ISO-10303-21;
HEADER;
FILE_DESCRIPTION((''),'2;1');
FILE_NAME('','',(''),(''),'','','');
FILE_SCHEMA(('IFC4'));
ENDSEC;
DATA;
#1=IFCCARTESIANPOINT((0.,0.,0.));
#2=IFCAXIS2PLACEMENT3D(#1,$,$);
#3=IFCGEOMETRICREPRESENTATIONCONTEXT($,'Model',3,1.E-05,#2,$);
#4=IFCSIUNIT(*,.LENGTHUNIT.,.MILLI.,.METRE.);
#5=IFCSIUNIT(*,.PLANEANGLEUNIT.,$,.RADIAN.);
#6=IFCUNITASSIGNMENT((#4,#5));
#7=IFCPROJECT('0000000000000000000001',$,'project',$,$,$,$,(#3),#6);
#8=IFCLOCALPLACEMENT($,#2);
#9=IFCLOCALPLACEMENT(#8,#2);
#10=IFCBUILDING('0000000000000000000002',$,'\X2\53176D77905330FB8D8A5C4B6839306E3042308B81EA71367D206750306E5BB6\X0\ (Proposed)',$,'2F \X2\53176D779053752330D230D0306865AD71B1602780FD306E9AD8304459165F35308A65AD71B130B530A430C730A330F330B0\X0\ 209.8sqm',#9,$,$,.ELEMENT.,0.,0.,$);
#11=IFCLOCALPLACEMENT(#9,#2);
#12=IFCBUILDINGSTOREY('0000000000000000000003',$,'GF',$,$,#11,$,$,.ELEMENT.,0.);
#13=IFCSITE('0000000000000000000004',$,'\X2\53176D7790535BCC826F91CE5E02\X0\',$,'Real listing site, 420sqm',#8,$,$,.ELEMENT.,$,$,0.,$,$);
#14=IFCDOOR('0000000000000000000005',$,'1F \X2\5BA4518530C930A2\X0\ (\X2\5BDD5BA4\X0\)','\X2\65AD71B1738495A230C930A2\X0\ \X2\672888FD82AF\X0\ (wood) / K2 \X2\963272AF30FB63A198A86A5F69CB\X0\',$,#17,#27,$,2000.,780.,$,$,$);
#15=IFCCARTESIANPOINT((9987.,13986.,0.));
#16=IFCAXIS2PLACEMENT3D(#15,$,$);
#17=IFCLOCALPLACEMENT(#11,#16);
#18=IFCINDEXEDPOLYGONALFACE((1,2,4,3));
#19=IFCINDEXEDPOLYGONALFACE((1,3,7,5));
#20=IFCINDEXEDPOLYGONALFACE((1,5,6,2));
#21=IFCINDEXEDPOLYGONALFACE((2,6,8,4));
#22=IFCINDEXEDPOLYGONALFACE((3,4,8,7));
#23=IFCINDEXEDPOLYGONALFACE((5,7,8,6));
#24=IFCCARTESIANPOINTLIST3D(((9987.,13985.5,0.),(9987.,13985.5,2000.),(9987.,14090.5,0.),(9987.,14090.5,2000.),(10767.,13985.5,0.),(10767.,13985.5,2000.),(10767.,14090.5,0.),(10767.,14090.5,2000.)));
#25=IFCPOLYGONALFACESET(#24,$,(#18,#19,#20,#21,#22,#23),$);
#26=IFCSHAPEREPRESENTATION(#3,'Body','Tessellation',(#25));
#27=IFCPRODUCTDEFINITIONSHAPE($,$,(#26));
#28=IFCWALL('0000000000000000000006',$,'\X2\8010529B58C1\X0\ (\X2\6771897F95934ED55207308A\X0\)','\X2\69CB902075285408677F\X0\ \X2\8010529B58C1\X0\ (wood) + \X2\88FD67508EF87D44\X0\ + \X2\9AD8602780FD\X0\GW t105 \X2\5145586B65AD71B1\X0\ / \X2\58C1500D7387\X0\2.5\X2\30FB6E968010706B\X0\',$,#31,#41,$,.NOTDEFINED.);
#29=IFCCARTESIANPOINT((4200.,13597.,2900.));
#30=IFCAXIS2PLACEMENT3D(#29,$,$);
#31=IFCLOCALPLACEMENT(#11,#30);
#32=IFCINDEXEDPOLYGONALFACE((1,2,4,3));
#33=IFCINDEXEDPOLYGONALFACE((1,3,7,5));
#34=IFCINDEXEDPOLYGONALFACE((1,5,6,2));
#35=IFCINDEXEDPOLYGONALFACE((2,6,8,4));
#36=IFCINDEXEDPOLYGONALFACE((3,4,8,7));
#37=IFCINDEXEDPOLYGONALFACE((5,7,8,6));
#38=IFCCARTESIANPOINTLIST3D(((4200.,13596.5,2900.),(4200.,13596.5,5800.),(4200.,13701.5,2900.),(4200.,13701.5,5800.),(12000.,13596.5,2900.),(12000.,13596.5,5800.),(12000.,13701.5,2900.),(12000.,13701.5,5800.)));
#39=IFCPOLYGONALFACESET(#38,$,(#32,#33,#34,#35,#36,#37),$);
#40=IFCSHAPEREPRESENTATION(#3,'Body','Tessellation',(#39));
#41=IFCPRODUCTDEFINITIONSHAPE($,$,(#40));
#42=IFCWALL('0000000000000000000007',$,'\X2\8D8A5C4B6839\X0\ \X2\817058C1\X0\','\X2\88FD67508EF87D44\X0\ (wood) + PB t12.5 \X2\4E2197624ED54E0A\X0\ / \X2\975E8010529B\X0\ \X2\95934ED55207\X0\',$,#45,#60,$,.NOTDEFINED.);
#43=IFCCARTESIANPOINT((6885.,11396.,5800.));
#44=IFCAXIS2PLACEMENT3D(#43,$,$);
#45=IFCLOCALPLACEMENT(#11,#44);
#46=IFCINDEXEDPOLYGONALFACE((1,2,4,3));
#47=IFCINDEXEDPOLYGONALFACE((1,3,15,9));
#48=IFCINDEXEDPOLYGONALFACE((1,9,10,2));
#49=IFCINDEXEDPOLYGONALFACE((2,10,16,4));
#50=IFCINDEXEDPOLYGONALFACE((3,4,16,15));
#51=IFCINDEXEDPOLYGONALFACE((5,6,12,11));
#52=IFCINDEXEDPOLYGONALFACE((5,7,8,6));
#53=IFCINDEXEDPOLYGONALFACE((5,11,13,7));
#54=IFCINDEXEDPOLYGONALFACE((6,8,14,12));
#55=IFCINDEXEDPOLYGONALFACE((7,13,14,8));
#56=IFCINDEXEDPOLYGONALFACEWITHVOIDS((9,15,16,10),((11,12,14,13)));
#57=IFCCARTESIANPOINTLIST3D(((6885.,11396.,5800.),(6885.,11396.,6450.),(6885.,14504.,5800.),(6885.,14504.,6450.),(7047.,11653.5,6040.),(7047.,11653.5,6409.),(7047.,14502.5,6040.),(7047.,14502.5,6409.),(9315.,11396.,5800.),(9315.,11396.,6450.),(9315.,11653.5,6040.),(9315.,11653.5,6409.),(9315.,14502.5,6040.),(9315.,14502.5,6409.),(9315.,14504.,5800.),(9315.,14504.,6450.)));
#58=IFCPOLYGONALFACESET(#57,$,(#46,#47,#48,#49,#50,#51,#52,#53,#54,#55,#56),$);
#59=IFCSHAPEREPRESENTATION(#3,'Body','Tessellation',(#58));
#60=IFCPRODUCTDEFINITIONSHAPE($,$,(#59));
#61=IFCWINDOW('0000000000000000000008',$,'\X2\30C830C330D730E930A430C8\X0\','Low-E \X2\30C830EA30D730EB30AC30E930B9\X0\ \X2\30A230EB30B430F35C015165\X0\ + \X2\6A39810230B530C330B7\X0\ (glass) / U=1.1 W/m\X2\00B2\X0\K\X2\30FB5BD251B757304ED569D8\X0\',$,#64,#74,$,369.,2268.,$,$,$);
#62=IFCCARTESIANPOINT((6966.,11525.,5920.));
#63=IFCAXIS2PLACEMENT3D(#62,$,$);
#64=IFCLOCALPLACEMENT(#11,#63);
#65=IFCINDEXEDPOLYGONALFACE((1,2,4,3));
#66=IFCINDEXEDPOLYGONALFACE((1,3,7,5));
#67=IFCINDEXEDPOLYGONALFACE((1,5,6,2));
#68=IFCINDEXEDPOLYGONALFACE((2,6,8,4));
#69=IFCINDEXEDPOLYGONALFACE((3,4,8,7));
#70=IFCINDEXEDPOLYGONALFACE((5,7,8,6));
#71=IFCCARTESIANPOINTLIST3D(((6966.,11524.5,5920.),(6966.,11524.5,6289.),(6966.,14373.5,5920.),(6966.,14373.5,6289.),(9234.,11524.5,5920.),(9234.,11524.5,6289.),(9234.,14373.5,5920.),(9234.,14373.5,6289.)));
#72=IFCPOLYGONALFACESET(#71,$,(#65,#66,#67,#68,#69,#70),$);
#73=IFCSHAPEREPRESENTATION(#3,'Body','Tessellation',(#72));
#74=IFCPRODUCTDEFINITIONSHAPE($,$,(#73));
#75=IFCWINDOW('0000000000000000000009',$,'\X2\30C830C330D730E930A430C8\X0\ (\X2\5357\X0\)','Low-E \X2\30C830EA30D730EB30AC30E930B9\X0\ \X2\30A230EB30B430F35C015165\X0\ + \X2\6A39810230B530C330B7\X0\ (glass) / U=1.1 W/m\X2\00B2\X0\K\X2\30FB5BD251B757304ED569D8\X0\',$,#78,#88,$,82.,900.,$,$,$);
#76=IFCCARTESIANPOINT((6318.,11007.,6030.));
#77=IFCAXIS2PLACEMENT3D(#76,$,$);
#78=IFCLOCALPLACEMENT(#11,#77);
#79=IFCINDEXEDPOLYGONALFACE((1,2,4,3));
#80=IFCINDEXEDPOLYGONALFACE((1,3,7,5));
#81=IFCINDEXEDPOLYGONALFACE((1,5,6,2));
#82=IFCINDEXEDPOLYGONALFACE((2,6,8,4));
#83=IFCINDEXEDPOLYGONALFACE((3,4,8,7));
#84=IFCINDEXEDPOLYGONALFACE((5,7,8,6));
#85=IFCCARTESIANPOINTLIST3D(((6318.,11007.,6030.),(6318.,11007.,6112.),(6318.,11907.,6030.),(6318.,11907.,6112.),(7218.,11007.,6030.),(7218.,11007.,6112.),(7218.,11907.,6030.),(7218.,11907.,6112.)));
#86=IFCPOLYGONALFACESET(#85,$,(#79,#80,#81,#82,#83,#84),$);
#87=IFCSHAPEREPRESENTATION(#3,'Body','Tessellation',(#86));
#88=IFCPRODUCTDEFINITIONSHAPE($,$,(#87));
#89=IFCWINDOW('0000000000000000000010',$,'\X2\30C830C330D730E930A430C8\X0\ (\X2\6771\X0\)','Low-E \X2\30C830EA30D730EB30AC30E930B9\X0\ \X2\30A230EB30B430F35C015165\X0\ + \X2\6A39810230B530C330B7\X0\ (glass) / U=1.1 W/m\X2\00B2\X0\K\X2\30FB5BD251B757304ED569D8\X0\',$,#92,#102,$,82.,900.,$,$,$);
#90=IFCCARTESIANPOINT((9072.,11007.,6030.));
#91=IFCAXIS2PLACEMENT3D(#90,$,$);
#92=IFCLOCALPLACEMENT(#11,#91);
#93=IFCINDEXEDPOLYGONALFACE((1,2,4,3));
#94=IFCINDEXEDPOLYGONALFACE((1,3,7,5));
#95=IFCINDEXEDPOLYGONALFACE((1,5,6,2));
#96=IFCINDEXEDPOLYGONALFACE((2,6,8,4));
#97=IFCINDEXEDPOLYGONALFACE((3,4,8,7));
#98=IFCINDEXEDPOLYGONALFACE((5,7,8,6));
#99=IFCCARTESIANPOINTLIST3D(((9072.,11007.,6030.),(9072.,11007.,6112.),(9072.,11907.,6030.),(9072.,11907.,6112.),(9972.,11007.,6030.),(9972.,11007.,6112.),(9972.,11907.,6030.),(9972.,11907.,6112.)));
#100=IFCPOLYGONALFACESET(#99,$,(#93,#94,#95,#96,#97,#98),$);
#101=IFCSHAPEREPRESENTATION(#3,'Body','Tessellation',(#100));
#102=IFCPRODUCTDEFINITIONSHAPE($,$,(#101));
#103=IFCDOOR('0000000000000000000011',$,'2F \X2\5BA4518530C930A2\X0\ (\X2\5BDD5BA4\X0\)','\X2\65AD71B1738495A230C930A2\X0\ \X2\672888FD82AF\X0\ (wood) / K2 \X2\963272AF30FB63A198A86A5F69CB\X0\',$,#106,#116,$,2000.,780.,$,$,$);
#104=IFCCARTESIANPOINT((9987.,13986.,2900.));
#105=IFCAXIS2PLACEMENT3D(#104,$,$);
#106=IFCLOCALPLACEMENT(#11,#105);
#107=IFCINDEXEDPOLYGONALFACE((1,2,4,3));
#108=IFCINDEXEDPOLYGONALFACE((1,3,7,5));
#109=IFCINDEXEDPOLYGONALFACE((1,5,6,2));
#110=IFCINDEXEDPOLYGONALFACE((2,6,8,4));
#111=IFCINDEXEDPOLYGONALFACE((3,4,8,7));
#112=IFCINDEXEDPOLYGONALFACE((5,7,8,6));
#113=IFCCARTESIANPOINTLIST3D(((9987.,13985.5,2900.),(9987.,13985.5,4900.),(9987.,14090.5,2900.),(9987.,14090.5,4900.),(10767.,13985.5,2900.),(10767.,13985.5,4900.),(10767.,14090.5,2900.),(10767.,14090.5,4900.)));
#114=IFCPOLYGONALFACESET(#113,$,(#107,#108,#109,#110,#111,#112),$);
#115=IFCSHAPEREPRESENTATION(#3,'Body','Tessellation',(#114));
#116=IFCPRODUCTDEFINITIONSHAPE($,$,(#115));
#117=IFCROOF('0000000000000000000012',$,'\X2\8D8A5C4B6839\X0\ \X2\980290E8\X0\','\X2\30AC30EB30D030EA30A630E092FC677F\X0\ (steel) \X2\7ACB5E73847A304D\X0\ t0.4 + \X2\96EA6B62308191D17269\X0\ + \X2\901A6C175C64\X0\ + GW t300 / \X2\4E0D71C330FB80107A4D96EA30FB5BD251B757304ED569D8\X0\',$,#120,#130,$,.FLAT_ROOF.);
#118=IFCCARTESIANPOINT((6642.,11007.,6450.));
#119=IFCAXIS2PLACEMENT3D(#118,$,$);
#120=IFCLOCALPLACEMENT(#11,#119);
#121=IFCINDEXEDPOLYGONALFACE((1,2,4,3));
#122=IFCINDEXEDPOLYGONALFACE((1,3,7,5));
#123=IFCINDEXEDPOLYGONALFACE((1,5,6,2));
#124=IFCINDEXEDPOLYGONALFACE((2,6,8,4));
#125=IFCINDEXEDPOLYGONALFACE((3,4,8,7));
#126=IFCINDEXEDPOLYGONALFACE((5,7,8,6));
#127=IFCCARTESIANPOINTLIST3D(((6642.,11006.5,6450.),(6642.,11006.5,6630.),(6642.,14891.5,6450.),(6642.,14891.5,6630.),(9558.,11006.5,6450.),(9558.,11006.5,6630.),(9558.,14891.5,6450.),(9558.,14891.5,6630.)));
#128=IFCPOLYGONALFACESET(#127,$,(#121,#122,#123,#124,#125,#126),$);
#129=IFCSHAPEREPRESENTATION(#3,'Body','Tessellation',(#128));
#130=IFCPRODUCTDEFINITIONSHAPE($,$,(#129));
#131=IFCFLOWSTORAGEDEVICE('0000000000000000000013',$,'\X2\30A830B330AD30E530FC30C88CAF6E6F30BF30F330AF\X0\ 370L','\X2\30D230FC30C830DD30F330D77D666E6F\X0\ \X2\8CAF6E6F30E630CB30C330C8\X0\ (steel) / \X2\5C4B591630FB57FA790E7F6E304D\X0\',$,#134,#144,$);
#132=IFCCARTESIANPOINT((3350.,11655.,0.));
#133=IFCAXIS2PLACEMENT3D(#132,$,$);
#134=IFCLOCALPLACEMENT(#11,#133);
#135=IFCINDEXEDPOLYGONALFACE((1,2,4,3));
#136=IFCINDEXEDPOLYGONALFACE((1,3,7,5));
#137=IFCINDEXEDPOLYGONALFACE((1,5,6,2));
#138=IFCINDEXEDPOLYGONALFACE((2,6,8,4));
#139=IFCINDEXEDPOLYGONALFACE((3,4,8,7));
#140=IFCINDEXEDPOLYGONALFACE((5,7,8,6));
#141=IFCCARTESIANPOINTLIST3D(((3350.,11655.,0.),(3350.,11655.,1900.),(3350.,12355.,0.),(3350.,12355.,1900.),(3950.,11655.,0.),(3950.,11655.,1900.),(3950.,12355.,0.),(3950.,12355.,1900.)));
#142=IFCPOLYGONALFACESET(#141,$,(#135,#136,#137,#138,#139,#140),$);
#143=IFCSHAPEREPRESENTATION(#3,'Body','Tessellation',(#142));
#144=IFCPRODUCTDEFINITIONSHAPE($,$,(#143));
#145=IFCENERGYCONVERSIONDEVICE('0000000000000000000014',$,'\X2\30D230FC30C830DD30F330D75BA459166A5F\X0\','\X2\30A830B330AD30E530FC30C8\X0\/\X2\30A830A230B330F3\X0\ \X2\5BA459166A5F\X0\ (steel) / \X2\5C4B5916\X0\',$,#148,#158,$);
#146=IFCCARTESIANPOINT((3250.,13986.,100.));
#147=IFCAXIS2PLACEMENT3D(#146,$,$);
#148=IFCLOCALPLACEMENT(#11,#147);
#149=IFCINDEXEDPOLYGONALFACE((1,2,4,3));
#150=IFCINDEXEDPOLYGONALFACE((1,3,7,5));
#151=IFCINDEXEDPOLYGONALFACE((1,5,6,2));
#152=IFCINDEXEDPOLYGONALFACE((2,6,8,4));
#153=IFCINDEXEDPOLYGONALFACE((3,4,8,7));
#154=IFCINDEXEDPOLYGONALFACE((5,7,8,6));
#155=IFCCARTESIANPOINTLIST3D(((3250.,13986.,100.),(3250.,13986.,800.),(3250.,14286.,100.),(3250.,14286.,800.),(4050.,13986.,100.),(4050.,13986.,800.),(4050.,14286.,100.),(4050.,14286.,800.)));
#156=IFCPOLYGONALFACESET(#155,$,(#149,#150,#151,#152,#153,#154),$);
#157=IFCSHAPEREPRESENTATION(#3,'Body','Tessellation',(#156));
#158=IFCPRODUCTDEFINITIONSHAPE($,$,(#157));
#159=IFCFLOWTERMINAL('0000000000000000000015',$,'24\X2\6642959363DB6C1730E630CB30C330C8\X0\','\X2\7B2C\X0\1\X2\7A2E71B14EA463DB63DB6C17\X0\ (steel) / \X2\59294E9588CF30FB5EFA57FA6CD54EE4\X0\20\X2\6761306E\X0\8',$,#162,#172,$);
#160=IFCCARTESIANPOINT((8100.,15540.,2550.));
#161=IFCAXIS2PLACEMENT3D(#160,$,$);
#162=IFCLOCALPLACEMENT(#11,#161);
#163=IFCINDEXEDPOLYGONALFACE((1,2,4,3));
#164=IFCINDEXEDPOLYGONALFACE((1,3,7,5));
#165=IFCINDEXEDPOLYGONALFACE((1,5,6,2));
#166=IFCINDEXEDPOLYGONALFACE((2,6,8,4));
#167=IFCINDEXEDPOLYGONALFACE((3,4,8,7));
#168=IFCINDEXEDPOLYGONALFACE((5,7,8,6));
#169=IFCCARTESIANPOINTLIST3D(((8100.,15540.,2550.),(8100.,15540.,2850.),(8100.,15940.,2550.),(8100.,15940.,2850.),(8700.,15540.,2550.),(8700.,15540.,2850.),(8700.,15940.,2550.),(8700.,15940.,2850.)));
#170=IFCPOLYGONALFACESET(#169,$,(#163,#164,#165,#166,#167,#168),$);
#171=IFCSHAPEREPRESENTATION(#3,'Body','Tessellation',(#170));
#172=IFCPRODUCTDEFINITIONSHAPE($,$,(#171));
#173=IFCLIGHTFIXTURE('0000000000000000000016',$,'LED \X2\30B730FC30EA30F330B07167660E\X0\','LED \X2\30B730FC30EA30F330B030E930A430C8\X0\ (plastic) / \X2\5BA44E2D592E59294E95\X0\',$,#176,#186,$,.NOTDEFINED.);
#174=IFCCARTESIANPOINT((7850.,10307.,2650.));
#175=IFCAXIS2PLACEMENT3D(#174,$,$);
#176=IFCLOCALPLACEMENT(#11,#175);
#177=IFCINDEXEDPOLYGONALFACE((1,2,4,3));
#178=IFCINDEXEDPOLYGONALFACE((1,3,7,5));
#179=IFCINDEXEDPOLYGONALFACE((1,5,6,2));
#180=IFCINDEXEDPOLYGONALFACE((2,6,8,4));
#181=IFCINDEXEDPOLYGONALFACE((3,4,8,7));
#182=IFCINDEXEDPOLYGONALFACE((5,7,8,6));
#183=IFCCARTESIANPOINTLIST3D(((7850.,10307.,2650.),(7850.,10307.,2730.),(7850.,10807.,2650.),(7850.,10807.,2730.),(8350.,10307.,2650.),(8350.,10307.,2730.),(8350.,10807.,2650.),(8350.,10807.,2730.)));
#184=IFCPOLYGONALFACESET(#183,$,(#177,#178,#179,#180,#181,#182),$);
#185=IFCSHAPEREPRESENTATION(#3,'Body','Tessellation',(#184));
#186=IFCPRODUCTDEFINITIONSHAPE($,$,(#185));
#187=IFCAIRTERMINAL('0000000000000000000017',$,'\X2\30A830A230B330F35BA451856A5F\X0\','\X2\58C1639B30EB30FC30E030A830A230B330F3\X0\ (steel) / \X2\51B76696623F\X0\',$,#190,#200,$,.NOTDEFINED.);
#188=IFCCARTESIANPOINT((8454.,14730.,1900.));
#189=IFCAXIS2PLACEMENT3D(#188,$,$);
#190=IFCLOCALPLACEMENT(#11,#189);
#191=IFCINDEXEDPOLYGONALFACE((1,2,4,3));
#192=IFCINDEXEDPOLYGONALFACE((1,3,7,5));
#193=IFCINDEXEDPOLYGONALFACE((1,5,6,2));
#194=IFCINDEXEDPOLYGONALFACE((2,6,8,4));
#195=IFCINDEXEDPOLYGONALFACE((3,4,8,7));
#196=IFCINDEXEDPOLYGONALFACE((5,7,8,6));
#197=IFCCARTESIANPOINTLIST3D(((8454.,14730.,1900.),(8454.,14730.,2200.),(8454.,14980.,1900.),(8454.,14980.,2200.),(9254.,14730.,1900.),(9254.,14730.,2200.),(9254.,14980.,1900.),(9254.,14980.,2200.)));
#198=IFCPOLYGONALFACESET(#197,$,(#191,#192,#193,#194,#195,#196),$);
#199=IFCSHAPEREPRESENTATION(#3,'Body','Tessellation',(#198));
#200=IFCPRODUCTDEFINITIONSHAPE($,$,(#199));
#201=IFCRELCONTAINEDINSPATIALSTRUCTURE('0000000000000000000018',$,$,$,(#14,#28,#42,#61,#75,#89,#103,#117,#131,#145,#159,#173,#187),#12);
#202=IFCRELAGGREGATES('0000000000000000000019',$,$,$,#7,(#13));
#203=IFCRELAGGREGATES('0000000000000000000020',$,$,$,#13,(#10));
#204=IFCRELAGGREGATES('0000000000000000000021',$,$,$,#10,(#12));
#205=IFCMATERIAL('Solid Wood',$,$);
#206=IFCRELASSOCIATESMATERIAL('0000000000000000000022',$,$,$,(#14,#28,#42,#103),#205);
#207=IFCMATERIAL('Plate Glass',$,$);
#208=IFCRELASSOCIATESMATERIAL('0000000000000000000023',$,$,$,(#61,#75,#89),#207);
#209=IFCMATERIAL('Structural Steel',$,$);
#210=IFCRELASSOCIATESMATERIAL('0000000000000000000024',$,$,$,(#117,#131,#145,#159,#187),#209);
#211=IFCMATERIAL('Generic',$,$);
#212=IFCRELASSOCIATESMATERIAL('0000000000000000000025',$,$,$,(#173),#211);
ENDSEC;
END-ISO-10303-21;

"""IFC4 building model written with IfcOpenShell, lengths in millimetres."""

from ifc_helpers import new_model, si_unit, frame, frame_2d, origin, place, context, project, spatial, rectangle, extrude, material, element, fill, save


model = new_model("IFC4")

# Units and contexts
model_context = context("Model", 3, precision=1e-05, world=origin())
ifc_project = project(units=[si_unit("LENGTHUNIT", "METRE", prefix="MILLI"), si_unit("PLANEANGLEUNIT", "RADIAN")], contexts=[model_context])

# Site, building, storey
site_placement = place(None, origin())
site = spatial("IfcSite", under=ifc_project, at=site_placement, Name="北海道富良野市", ObjectType="Real listing site, 420sqm", CompositionType="ELEMENT", RefElevation=0.0)
building_placement = place(site_placement, origin())
building = spatial("IfcBuilding", under=site, at=building_placement, Name="北海道・越屋根のある自然素材の家 (Proposed)", ObjectType="2F 北海道産ヒバと断熱性能の高い外張り断熱サイディング 209.8sqm", CompositionType="ELEMENT", ElevationOfRefHeight=0.0, ElevationOfTerrain=0.0)
storey_placement = place(building_placement, origin())
storey = spatial("IfcBuildingStorey", under=building, at=storey_placement, Name="GF", CompositionType="ELEMENT", Elevation=0.0)

# Shared definitions
ifc_material_1 = material(Name="Solid Wood")

# Door
door_1_placement = place(storey_placement, frame((9987.0, 13986.0, 0.0)))
element("IfcDoor", 1, at=door_1_placement, inside=storey, material=ifc_material_1, Name="1F 室内ドア (寝室)", Description="断熱玄関ドア 木製芯 (wood) / K2 防犯・採風機構", OverallHeight=2000.0, OverallWidth=780.0, context=model_context, shape_type="SweptSolid", body=[
    extrude(rectangle(XDim=780.0, YDim=105.0, at=frame_2d((390.0, 52.0))), frame((9987.0, 13986.0, 0.0)), (0.0, 0.0, 1.0), 2000.0),
])

# Wall
wall_1_placement = place(storey_placement, frame((4200.0, 13597.0, 2900.0)))
element("IfcWall", 2, at=wall_1_placement, inside=storey, material=ifc_material_1, Name="耐力壁 (東西間仕切り)", Description="構造用合板 耐力壁 (wood) + 製材軸組 + 高性能GW t105 充填断熱 / 壁倍率2.5・準耐火", PredefinedType="NOTDEFINED", context=model_context, shape_type="SweptSolid", body=[
    extrude(rectangle(XDim=7800.0, YDim=105.0, at=frame_2d((3900.0, 52.0))), frame((4200.0, 13597.0, 2900.0)), (0.0, 0.0, 1.0), 2900.0),
])

# Wall, openings, windows
wall_2_placement = place(storey_placement, frame((6885.0, 11396.0, 5800.0)))
wall_2 = element("IfcWall", 3, at=wall_2_placement, inside=storey, material=ifc_material_1, Name="越屋根 腰壁", Description="製材軸組 (wood) + PB t12.5 両面仕上 / 非耐力 間仕切", PredefinedType="NOTDEFINED", context=model_context, shape_type="SweptSolid", body=[
    extrude(rectangle(XDim=2430.0, YDim=3108.0, at=frame_2d((1215.0, 1554.0))), frame((6885.0, 11396.0, 5800.0)), (0.0, 0.0, 1.0), 650.0),
])
opening_1_placement = place(storey_placement, frame((6966.0, 11525.0, 5920.0)))
opening_1 = element("IfcOpeningElement", 4, at=opening_1_placement, cuts=wall_2, PredefinedType="NOTDEFINED", context=model_context, shape_type="SweptSolid", body=[
    extrude(rectangle(XDim=2268.0, YDim=2849.0, at=frame_2d((1134.0, 1424.0))), frame((6966.0, 11525.0, 5920.0)), (0.0, 0.0, 1.0), 369.0),
])
opening_2_placement = place(storey_placement, frame((6318.0, 11007.0, 6030.0)))
opening_2 = element("IfcOpeningElement", 5, at=opening_2_placement, cuts=wall_2, PredefinedType="NOTDEFINED", context=model_context, shape_type="SweptSolid", body=[
    extrude(rectangle(XDim=900.0, YDim=900.0, at=frame_2d((450.0, 450.0))), frame((6318.0, 11007.0, 6030.0)), (0.0, 0.0, 1.0), 82.0),
])
opening_3_placement = place(storey_placement, frame((9072.0, 11007.0, 6030.0)))
opening_3 = element("IfcOpeningElement", 6, at=opening_3_placement, cuts=wall_2, PredefinedType="NOTDEFINED", context=model_context, shape_type="SweptSolid", body=[
    extrude(rectangle(XDim=900.0, YDim=900.0, at=frame_2d((450.0, 450.0))), frame((9072.0, 11007.0, 6030.0)), (0.0, 0.0, 1.0), 82.0),
])
ifc_material_2 = material(Name="Plate Glass")
window_1_placement = place(storey_placement, frame((6966.0, 11525.0, 5920.0)))
window_1 = element("IfcWindow", 7, at=window_1_placement, inside=storey, material=ifc_material_2, Name="トップライト", Description="Low-E トリプルガラス アルゴン封入 + 樹脂サッシ (glass) / U=1.1 W/m²K・寒冷地仕様", OverallHeight=369.0, OverallWidth=2268.0, context=model_context, shape_type="SweptSolid", body=[
    extrude(rectangle(XDim=2268.0, YDim=2849.0, at=frame_2d((1134.0, 1424.0))), frame((6966.0, 11525.0, 5920.0)), (0.0, 0.0, 1.0), 369.0),
])
fill(opening_1, window_1)
window_2_placement = place(storey_placement, frame((6318.0, 11007.0, 6030.0)))
window_2 = element("IfcWindow", 8, at=window_2_placement, inside=storey, material=ifc_material_2, Name="トップライト (南)", Description="Low-E トリプルガラス アルゴン封入 + 樹脂サッシ (glass) / U=1.1 W/m²K・寒冷地仕様", OverallHeight=82.0, OverallWidth=900.0, context=model_context, shape_type="SweptSolid", body=[
    extrude(rectangle(XDim=900.0, YDim=900.0, at=frame_2d((450.0, 450.0))), frame((6318.0, 11007.0, 6030.0)), (0.0, 0.0, 1.0), 82.0),
])
fill(opening_2, window_2)
window_3_placement = place(storey_placement, frame((9072.0, 11007.0, 6030.0)))
window_3 = element("IfcWindow", 9, at=window_3_placement, inside=storey, material=ifc_material_2, Name="トップライト (東)", Description="Low-E トリプルガラス アルゴン封入 + 樹脂サッシ (glass) / U=1.1 W/m²K・寒冷地仕様", OverallHeight=82.0, OverallWidth=900.0, context=model_context, shape_type="SweptSolid", body=[
    extrude(rectangle(XDim=900.0, YDim=900.0, at=frame_2d((450.0, 450.0))), frame((9072.0, 11007.0, 6030.0)), (0.0, 0.0, 1.0), 82.0),
])
fill(opening_3, window_3)

# Door
door_2_placement = place(storey_placement, frame((9987.0, 13986.0, 2900.0)))
element("IfcDoor", 10, at=door_2_placement, inside=storey, material=ifc_material_1, Name="2F 室内ドア (寝室)", Description="断熱玄関ドア 木製芯 (wood) / K2 防犯・採風機構", OverallHeight=2000.0, OverallWidth=780.0, context=model_context, shape_type="SweptSolid", body=[
    extrude(rectangle(XDim=780.0, YDim=105.0, at=frame_2d((390.0, 52.0))), frame((9987.0, 13986.0, 2900.0)), (0.0, 0.0, 1.0), 2000.0),
])

# Roof
ifc_material_3 = material(Name="Structural Steel")
roof_placement = place(storey_placement, frame((6642.0, 11007.0, 6450.0)))
element("IfcRoof", 11, at=roof_placement, inside=storey, material=ifc_material_3, Name="越屋根 頂部", Description="ガルバリウム鋼板 (steel) 立平葺き t0.4 + 雪止め金物 + 通気層 + GW t300 / 不燃・耐積雪・寒冷地仕様", PredefinedType="FLAT_ROOF", context=model_context, shape_type="SweptSolid", body=[
    extrude(rectangle(XDim=2916.0, YDim=3885.0, at=frame_2d((1458.0, 1942.0))), frame((6642.0, 11007.0, 6450.0)), (0.0, 0.0, 1.0), 180.0),
])

# Flow storage device
flow_storage_device_placement = place(storey_placement, frame((3350.0, 11655.0, 0.0)))
element("IfcFlowStorageDevice", 12, at=flow_storage_device_placement, inside=storey, material=ifc_material_3, Name="エコキュート貯湯タンク 370L", Description="ヒートポンプ給湯 貯湯ユニット (steel) / 屋外・基礎置き", context=model_context, shape_type="SweptSolid", body=[
    extrude(rectangle(XDim=600.0, YDim=700.0, at=frame_2d((300.0, 350.0))), frame((3350.0, 11655.0, 0.0)), (0.0, 0.0, 1.0), 1900.0),
])

# Energy conversion device
energy_conversion_device_placement = place(storey_placement, frame((3250.0, 13986.0, 100.0)))
element("IfcEnergyConversionDevice", 13, at=energy_conversion_device_placement, inside=storey, material=ifc_material_3, Name="ヒートポンプ室外機", Description="エコキュート/エアコン 室外機 (steel) / 屋外", context=model_context, shape_type="SweptSolid", body=[
    extrude(rectangle(XDim=800.0, YDim=300.0, at=frame_2d((400.0, 150.0))), frame((3250.0, 13986.0, 100.0)), (0.0, 0.0, 1.0), 700.0),
])

# Flow terminal
flow_terminal_placement = place(storey_placement, frame((8100.0, 15540.0, 2550.0)))
element("IfcFlowTerminal", 14, at=flow_terminal_placement, inside=storey, material=ifc_material_3, Name="24時間換気ユニット", Description="第1種熱交換換気 (steel) / 天井裏・建基法令20条の8", context=model_context, shape_type="SweptSolid", body=[
    extrude(rectangle(XDim=600.0, YDim=400.0, at=frame_2d((300.0, 200.0))), frame((8100.0, 15540.0, 2550.0)), (0.0, 0.0, 1.0), 300.0),
])

# Light fixture
ifc_material_4 = material(Name="Generic")
light_fixture_1_placement = place(storey_placement, frame((7850.0, 10307.0, 2650.0)))
element("IfcLightFixture", 15, at=light_fixture_1_placement, inside=storey, material=ifc_material_4, Name="LED シーリング照明", Description="LED シーリングライト (plastic) / 室中央天井", PredefinedType="NOTDEFINED", context=model_context, shape_type="SweptSolid", body=[
    extrude(rectangle(XDim=500.0, YDim=500.0, at=frame_2d((250.0, 250.0))), frame((7850.0, 10307.0, 2650.0)), (0.0, 0.0, 1.0), 80.0),
])

# Air terminal
air_terminal_placement = place(storey_placement, frame((8454.0, 14730.0, 1900.0)))
element("IfcAirTerminal", 16, at=air_terminal_placement, inside=storey, material=ifc_material_3, Name="エアコン室内機", Description="壁掛ルームエアコン (steel) / 冷暖房", PredefinedType="NOTDEFINED", context=model_context, shape_type="SweptSolid", body=[
    extrude(rectangle(XDim=800.0, YDim=250.0, at=frame_2d((400.0, 125.0))), frame((8454.0, 14730.0, 1900.0)), (0.0, 0.0, 1.0), 300.0),
])

save(model, "model.ifc")
